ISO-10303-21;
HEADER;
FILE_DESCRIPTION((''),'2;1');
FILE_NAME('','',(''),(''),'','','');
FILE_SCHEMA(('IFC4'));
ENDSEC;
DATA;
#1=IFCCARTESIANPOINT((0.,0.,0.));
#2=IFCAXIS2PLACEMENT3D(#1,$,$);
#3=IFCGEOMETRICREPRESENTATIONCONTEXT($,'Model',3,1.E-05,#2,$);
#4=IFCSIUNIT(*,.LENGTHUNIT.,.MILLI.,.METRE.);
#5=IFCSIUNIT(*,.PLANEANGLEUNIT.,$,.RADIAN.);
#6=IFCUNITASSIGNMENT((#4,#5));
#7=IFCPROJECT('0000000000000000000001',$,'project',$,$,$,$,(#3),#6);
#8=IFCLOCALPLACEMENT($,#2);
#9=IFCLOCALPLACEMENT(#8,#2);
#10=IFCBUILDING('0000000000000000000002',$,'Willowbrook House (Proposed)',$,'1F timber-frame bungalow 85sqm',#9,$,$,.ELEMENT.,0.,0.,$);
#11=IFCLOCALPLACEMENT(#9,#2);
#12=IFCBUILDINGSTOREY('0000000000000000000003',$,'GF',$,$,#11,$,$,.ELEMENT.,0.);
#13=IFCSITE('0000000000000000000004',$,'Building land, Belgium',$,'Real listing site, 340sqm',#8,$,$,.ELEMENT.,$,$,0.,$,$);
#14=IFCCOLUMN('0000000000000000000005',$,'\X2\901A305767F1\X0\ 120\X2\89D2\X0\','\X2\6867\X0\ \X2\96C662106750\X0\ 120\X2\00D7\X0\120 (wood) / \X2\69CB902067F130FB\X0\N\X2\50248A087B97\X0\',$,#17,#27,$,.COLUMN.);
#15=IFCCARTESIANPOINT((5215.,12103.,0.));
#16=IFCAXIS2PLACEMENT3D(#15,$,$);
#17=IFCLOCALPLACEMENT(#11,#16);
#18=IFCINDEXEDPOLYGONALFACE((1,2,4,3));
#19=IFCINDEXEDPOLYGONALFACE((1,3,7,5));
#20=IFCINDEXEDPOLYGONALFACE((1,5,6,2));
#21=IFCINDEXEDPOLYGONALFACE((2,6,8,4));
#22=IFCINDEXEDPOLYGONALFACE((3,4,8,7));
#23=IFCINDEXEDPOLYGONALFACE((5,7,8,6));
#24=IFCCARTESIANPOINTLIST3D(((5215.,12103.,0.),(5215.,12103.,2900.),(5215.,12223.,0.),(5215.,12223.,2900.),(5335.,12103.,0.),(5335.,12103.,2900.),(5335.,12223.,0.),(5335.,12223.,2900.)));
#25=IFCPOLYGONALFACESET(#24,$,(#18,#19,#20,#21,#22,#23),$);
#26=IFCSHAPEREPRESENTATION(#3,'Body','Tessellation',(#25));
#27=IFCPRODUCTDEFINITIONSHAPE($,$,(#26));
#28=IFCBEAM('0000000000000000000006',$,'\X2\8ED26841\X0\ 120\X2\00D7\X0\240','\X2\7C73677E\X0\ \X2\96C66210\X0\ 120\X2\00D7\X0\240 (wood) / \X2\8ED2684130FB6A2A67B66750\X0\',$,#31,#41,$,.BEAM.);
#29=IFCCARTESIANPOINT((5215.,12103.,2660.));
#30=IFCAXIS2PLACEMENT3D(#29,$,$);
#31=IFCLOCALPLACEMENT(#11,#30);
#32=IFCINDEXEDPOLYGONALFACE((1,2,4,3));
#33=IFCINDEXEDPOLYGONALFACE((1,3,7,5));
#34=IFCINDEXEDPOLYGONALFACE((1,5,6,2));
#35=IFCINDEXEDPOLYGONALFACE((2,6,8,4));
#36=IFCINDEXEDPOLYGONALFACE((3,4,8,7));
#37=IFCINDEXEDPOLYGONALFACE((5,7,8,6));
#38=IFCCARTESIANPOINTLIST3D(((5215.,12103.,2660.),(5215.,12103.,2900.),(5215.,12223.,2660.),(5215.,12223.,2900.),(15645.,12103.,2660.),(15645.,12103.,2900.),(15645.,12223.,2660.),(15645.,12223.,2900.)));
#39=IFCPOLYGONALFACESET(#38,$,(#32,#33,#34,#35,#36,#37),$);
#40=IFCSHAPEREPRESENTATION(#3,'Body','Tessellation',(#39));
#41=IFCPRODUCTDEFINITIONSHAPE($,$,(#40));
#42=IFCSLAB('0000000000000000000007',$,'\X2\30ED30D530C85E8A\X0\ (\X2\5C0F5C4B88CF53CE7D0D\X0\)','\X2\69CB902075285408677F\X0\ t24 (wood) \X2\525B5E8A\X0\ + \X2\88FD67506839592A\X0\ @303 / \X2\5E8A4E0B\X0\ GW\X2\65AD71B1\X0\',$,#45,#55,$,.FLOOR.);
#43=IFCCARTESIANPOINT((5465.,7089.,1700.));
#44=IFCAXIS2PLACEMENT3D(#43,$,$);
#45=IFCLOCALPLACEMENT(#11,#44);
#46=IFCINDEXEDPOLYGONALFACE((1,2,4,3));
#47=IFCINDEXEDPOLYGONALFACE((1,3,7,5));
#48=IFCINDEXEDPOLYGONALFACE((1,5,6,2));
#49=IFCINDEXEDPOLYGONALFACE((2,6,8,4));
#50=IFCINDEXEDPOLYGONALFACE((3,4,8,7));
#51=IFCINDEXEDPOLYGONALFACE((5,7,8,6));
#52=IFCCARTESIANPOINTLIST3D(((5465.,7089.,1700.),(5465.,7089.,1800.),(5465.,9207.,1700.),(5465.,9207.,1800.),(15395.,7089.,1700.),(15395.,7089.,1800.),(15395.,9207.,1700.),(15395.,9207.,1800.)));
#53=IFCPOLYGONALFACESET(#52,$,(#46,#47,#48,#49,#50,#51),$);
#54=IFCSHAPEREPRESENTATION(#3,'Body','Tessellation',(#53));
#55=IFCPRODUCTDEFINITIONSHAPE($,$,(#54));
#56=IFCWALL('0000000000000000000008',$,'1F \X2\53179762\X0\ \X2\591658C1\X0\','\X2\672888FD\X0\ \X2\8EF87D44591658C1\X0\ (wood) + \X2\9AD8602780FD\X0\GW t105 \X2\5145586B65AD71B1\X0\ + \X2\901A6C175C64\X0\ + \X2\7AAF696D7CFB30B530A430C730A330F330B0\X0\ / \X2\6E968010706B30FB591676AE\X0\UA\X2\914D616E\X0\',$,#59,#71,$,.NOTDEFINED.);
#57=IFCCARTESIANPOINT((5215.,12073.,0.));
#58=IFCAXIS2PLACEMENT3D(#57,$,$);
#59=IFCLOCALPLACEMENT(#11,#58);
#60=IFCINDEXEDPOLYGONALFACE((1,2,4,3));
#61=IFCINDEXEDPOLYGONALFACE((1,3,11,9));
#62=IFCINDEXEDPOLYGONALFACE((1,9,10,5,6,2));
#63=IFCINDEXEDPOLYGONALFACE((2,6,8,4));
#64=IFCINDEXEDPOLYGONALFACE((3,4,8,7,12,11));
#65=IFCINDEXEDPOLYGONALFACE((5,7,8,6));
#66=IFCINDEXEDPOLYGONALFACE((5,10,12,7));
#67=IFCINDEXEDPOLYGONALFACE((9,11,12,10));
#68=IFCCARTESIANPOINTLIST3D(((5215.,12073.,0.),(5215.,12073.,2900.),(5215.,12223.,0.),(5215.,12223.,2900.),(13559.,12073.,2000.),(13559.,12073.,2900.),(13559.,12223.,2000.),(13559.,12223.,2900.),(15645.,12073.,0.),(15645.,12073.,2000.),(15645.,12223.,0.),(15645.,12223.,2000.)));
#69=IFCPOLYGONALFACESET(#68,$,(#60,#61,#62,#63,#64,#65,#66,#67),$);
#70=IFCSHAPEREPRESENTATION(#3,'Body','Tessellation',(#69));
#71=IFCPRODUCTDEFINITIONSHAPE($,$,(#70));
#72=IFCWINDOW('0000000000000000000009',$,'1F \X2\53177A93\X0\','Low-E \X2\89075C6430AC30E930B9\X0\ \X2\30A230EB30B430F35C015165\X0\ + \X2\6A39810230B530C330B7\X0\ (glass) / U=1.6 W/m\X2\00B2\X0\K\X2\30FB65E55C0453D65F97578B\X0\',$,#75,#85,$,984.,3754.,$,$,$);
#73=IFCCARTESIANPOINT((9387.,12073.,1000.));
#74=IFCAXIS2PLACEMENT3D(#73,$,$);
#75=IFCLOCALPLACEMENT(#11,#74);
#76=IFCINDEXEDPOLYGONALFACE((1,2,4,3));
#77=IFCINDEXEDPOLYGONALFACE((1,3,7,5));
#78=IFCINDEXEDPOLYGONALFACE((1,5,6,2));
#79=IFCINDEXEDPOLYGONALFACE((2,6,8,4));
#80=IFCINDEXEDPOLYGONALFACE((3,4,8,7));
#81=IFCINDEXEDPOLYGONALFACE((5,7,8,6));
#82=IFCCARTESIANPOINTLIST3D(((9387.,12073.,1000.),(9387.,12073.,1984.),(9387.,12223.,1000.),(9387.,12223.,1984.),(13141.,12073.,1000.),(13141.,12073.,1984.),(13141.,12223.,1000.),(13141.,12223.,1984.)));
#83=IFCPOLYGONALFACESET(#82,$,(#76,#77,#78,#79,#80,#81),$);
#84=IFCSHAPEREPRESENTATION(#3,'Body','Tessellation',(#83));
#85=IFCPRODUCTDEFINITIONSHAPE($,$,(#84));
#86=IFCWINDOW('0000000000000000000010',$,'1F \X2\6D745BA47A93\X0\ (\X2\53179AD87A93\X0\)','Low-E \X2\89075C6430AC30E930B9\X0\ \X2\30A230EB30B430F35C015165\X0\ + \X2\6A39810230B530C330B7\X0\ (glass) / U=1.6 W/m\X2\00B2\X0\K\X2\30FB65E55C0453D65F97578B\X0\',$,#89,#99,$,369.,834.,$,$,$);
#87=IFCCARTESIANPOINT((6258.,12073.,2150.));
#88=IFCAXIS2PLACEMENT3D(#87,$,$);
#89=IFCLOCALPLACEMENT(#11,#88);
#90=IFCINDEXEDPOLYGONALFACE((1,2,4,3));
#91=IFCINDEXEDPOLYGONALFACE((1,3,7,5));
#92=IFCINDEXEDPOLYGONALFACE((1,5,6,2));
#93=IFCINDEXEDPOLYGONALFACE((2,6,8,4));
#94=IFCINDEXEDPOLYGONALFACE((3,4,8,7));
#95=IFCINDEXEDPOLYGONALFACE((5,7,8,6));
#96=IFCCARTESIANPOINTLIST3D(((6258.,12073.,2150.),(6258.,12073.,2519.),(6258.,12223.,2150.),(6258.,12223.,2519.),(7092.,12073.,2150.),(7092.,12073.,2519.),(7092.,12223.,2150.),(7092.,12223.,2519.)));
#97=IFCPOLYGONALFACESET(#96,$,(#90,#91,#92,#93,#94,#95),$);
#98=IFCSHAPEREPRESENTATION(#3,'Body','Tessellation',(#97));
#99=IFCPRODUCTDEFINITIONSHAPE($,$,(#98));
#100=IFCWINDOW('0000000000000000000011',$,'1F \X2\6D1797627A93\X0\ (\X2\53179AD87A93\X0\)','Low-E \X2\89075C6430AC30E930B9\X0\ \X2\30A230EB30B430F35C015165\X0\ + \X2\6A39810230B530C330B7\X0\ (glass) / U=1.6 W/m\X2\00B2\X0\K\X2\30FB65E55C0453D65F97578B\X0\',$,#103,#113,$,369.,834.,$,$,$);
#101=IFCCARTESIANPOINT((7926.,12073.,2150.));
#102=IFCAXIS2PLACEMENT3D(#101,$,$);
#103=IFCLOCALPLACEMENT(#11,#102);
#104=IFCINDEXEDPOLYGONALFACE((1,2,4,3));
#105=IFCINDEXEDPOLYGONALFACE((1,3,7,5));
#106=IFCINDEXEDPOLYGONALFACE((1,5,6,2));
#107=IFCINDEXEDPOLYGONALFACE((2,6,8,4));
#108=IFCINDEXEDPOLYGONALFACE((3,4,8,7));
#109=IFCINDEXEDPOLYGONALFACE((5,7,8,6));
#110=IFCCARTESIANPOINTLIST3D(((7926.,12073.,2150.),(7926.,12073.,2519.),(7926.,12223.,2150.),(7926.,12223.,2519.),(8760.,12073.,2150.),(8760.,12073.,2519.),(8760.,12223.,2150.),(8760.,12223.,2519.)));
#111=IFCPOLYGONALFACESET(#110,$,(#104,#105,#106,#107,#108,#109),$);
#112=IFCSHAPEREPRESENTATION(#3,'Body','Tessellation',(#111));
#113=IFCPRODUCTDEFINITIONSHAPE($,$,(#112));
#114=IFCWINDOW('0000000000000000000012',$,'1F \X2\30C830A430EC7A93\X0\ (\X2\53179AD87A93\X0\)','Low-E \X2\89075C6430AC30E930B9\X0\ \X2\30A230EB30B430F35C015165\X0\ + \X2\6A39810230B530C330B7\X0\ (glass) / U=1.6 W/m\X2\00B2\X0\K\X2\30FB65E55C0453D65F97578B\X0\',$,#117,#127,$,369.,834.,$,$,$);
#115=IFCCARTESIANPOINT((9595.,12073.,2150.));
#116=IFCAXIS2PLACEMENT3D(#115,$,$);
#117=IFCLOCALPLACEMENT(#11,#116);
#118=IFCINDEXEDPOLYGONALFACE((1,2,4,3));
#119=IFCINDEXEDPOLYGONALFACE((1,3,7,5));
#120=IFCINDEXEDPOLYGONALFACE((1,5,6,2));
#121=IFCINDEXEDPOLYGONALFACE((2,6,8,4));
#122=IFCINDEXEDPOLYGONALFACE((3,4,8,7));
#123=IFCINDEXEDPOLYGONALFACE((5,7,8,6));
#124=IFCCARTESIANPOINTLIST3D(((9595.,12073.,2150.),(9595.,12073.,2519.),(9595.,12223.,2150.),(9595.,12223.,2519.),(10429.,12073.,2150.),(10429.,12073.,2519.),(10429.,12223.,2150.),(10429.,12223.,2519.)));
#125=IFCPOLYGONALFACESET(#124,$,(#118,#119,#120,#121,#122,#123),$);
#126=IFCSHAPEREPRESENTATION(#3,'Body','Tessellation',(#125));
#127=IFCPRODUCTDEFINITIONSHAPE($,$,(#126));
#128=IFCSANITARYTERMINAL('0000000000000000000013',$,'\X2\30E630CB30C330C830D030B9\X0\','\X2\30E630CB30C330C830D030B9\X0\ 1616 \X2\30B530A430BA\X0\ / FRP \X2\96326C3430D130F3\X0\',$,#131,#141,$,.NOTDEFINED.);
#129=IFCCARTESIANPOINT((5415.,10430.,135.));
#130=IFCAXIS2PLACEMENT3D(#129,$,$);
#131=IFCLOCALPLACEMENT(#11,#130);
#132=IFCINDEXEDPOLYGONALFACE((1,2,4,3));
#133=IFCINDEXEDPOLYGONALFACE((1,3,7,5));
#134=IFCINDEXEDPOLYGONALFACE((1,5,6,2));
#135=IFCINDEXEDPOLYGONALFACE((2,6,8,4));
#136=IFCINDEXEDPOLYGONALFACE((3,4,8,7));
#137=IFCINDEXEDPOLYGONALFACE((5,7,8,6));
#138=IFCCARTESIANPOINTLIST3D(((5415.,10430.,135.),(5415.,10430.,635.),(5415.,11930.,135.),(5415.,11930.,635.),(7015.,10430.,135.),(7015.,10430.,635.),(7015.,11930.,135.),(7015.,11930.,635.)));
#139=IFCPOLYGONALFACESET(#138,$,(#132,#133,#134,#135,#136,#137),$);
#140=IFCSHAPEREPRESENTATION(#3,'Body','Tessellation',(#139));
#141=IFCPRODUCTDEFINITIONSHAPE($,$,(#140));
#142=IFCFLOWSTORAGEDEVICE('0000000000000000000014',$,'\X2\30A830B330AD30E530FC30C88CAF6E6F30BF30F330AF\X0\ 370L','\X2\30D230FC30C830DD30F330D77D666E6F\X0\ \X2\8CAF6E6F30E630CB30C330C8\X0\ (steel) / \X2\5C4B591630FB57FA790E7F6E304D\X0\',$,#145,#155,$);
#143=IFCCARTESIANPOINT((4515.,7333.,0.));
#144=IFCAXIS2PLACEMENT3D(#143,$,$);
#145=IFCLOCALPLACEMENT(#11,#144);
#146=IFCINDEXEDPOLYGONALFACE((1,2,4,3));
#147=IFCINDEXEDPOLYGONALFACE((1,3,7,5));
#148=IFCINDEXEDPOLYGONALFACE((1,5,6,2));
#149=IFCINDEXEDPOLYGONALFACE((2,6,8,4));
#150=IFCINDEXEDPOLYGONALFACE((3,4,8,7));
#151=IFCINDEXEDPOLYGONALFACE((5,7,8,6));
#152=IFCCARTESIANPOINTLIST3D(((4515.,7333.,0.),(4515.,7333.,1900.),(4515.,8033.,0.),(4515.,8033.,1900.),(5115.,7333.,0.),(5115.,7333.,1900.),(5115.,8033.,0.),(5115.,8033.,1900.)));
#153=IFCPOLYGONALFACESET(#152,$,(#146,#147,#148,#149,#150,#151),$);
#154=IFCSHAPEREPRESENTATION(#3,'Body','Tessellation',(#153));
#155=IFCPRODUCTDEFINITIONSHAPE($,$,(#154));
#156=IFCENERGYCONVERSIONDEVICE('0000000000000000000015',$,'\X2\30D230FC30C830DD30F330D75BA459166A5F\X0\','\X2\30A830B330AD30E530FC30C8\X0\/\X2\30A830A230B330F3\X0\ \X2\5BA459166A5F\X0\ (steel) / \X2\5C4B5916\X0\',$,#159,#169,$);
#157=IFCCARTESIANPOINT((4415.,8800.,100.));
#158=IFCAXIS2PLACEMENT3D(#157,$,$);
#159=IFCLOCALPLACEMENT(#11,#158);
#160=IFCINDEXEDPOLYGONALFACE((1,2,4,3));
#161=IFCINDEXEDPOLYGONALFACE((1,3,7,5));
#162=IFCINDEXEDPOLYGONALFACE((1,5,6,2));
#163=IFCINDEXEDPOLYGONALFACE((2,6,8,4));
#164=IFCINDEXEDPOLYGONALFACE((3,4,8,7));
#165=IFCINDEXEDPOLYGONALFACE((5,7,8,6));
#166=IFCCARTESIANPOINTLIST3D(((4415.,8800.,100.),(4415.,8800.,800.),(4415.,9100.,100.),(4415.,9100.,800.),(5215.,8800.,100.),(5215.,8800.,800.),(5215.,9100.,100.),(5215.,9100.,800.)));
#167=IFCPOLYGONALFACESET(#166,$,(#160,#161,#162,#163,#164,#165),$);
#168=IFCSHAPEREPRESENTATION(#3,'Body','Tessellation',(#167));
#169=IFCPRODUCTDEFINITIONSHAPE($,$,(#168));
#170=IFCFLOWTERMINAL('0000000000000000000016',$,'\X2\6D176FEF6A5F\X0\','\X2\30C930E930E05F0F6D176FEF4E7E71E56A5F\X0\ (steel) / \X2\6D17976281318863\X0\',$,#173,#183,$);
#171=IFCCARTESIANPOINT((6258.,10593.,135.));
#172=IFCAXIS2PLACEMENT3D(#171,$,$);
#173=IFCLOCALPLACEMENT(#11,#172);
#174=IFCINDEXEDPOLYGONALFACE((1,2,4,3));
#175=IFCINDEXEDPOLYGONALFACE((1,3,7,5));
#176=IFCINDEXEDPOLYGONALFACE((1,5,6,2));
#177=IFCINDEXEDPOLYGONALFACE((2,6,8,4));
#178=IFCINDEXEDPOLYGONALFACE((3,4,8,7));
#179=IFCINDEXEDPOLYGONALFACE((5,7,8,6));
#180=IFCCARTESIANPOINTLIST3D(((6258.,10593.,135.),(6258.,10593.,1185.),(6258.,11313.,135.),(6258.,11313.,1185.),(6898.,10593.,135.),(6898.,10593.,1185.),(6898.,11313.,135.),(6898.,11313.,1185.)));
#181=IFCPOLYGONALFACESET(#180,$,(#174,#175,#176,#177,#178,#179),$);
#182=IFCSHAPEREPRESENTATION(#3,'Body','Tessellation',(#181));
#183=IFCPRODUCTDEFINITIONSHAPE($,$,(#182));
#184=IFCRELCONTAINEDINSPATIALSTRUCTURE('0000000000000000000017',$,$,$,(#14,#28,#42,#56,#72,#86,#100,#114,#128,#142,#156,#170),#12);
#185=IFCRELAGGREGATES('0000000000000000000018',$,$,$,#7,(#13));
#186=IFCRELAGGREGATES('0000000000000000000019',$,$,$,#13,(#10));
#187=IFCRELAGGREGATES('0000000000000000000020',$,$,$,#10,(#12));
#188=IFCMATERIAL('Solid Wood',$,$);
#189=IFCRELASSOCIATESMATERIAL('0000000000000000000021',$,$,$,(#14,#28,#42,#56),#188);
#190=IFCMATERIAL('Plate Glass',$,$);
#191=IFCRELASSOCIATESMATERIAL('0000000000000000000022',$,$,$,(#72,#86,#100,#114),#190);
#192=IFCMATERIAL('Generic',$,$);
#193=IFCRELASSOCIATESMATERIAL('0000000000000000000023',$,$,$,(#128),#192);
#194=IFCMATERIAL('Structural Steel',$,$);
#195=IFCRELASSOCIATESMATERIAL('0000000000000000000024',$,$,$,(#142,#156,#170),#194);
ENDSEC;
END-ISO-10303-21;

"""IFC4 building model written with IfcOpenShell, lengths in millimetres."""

from ifc_helpers import new_model, si_unit, frame, frame_2d, origin, place, context, project, spatial, rectangle, extrude, material, element, fill, save


model = new_model("IFC4")

# Units and contexts
model_context = context("Model", 3, precision=1e-05, world=origin())
ifc_project = project(units=[si_unit("LENGTHUNIT", "METRE", prefix="MILLI"), si_unit("PLANEANGLEUNIT", "RADIAN")], contexts=[model_context])

# Site, building, storey
site_placement = place(None, origin())
site = spatial("IfcSite", under=ifc_project, at=site_placement, Name="Building land, Belgium", ObjectType="Real listing site, 340sqm", CompositionType="ELEMENT", RefElevation=0.0)
building_placement = place(site_placement, origin())
building = spatial("IfcBuilding", under=site, at=building_placement, Name="Willowbrook House (Proposed)", ObjectType="1F timber-frame bungalow 85sqm", CompositionType="ELEMENT", ElevationOfRefHeight=0.0, ElevationOfTerrain=0.0)
storey_placement = place(building_placement, origin())
storey = spatial("IfcBuildingStorey", under=building, at=storey_placement, Name="GF", CompositionType="ELEMENT", Elevation=0.0)

# Column
ifc_material_1 = material(Name="Solid Wood")
column_1_placement = place(storey_placement, frame((5215.0, 12103.0, 0.0)))
element("IfcColumn", 1, at=column_1_placement, inside=storey, material=ifc_material_1, Name="通し柱 120角", Description="桧 集成材 120×120 (wood) / 構造柱・N値計算", PredefinedType="COLUMN", context=model_context, shape_type="SweptSolid", body=[
    extrude(rectangle(XDim=120.0, YDim=120.0, at=frame_2d((60.0, 60.0))), frame((5215.0, 12103.0, 0.0)), (0.0, 0.0, 1.0), 2900.0),
])

# Beam
beam_1_placement = place(storey_placement, frame((5215.0, 12103.0, 2660.0)))
element("IfcBeam", 2, at=beam_1_placement, inside=storey, material=ifc_material_1, Name="軒桁 120×240", Description="米松 集成 120×240 (wood) / 軒桁・横架材", PredefinedType="BEAM", context=model_context, shape_type="SweptSolid", body=[
    extrude(rectangle(XDim=10430.0, YDim=120.0, at=frame_2d((5215.0, 60.0))), frame((5215.0, 12103.0, 2660.0)), (0.0, 0.0, 1.0), 240.0),
])

# Slab
slab_placement = place(storey_placement, frame((5465.0, 7089.0, 1700.0)))
element("IfcSlab", 3, at=slab_placement, inside=storey, material=ifc_material_1, Name="ロフト床 (小屋裏収納)", Description="構造用合板 t24 (wood) 剛床 + 製材根太 @303 / 床下 GW断熱", PredefinedType="FLOOR", context=model_context, shape_type="SweptSolid", body=[
    extrude(rectangle(XDim=9930.0, YDim=2118.0, at=frame_2d((4965.0, 1059.0))), frame((5465.0, 7089.0, 1700.0)), (0.0, 0.0, 1.0), 100.0),
])

# Wall, openings, windows
wall_1_placement = place(storey_placement, frame((5215.0, 12073.0, 0.0)))
wall_1 = element("IfcWall", 4, at=wall_1_placement, inside=storey, material=ifc_material_1, Name="1F 北面 外壁", Description="木製 軸組外壁 (wood) + 高性能GW t105 充填断熱 + 通気層 + 窯業系サイディング / 準耐火・外皮UA配慮", PredefinedType="NOTDEFINED", context=model_context, shape_type="SweptSolid", body=[
    extrude(rectangle(XDim=10430.0, YDim=150.0, at=frame_2d((5215.0, 75.0))), frame((5215.0, 12073.0, 0.0)), (0.0, 0.0, 1.0), 2900.0),
])
opening_1_placement = place(storey_placement, frame((9387.0, 12073.0, 1000.0)))
opening_1 = element("IfcOpeningElement", 5, at=opening_1_placement, cuts=wall_1, PredefinedType="NOTDEFINED", context=model_context, shape_type="SweptSolid", body=[
    extrude(rectangle(XDim=3754.0, YDim=150.0, at=frame_2d((1877.0, 75.0))), frame((9387.0, 12073.0, 1000.0)), (0.0, 0.0, 1.0), 984.0),
])
opening_2_placement = place(storey_placement, frame((6258.0, 12073.0, 2150.0)))
opening_2 = element("IfcOpeningElement", 6, at=opening_2_placement, cuts=wall_1, PredefinedType="NOTDEFINED", context=model_context, shape_type="SweptSolid", body=[
    extrude(rectangle(XDim=834.0, YDim=150.0, at=frame_2d((417.0, 75.0))), frame((6258.0, 12073.0, 2150.0)), (0.0, 0.0, 1.0), 369.0),
])
opening_3_placement = place(storey_placement, frame((7926.0, 12073.0, 2150.0)))
opening_3 = element("IfcOpeningElement", 7, at=opening_3_placement, cuts=wall_1, PredefinedType="NOTDEFINED", context=model_context, shape_type="SweptSolid", body=[
    extrude(rectangle(XDim=834.0, YDim=150.0, at=frame_2d((417.0, 75.0))), frame((7926.0, 12073.0, 2150.0)), (0.0, 0.0, 1.0), 369.0),
])
opening_4_placement = place(storey_placement, frame((9595.0, 12073.0, 2150.0)))
opening_4 = element("IfcOpeningElement", 8, at=opening_4_placement, cuts=wall_1, PredefinedType="NOTDEFINED", context=model_context, shape_type="SweptSolid", body=[
    extrude(rectangle(XDim=834.0, YDim=150.0, at=frame_2d((417.0, 75.0))), frame((9595.0, 12073.0, 2150.0)), (0.0, 0.0, 1.0), 369.0),
])
ifc_material_2 = material(Name="Plate Glass")
window_1_placement = place(storey_placement, frame((9387.0, 12073.0, 1000.0)))
window_1 = element("IfcWindow", 9, at=window_1_placement, inside=storey, material=ifc_material_2, Name="1F 北窓", Description="Low-E 複層ガラス アルゴン封入 + 樹脂サッシ (glass) / U=1.6 W/m²K・日射取得型", OverallHeight=984.0, OverallWidth=3754.0, context=model_context, shape_type="SweptSolid", body=[
    extrude(rectangle(XDim=3754.0, YDim=150.0, at=frame_2d((1877.0, 75.0))), frame((9387.0, 12073.0, 1000.0)), (0.0, 0.0, 1.0), 984.0),
])
fill(opening_1, window_1)
window_2_placement = place(storey_placement, frame((6258.0, 12073.0, 2150.0)))
window_2 = element("IfcWindow", 10, at=window_2_placement, inside=storey, material=ifc_material_2, Name="1F 浴室窓 (北高窓)", Description="Low-E 複層ガラス アルゴン封入 + 樹脂サッシ (glass) / U=1.6 W/m²K・日射取得型", OverallHeight=369.0, OverallWidth=834.0, context=model_context, shape_type="SweptSolid", body=[
    extrude(rectangle(XDim=834.0, YDim=150.0, at=frame_2d((417.0, 75.0))), frame((6258.0, 12073.0, 2150.0)), (0.0, 0.0, 1.0), 369.0),
])
fill(opening_2, window_2)
window_3_placement = place(storey_placement, frame((7926.0, 12073.0, 2150.0)))
window_3 = element("IfcWindow", 11, at=window_3_placement, inside=storey, material=ifc_material_2, Name="1F 洗面窓 (北高窓)", Description="Low-E 複層ガラス アルゴン封入 + 樹脂サッシ (glass) / U=1.6 W/m²K・日射取得型", OverallHeight=369.0, OverallWidth=834.0, context=model_context, shape_type="SweptSolid", body=[
    extrude(rectangle(XDim=834.0, YDim=150.0, at=frame_2d((417.0, 75.0))), frame((7926.0, 12073.0, 2150.0)), (0.0, 0.0, 1.0), 369.0),
])
fill(opening_3, window_3)
window_4_placement = place(storey_placement, frame((9595.0, 12073.0, 2150.0)))
window_4 = element("IfcWindow", 12, at=window_4_placement, inside=storey, material=ifc_material_2, Name="1F トイレ窓 (北高窓)", Description="Low-E 複層ガラス アルゴン封入 + 樹脂サッシ (glass) / U=1.6 W/m²K・日射取得型", OverallHeight=369.0, OverallWidth=834.0, context=model_context, shape_type="SweptSolid", body=[
    extrude(rectangle(XDim=834.0, YDim=150.0, at=frame_2d((417.0, 75.0))), frame((9595.0, 12073.0, 2150.0)), (0.0, 0.0, 1.0), 369.0),
])
fill(opening_4, window_4)

# Sanitary terminal
ifc_material_3 = material(Name="Generic")
sanitary_terminal_placement = place(storey_placement, frame((5415.0, 10430.0, 135.0)))
element("IfcSanitaryTerminal", 13, at=sanitary_terminal_placement, inside=storey, material=ifc_material_3, Name="ユニットバス", Description="ユニットバス 1616 サイズ / FRP 防水パン", PredefinedType="NOTDEFINED", context=model_context, shape_type="SweptSolid", body=[
    extrude(rectangle(XDim=1600.0, YDim=1500.0, at=frame_2d((800.0, 750.0))), frame((5415.0, 10430.0, 135.0)), (0.0, 0.0, 1.0), 500.0),
])

# Flow storage device
ifc_material_4 = material(Name="Structural Steel")
flow_storage_device_placement = place(storey_placement, frame((4515.0, 7333.0, 0.0)))
element("IfcFlowStorageDevice", 14, at=flow_storage_device_placement, inside=storey, material=ifc_material_4, Name="エコキュート貯湯タンク 370L", Description="ヒートポンプ給湯 貯湯ユニット (steel) / 屋外・基礎置き", context=model_context, shape_type="SweptSolid", body=[
    extrude(rectangle(XDim=600.0, YDim=700.0, at=frame_2d((300.0, 350.0))), frame((4515.0, 7333.0, 0.0)), (0.0, 0.0, 1.0), 1900.0),
])

# Energy conversion device
energy_conversion_device_placement = place(storey_placement, frame((4415.0, 8800.0, 100.0)))
element("IfcEnergyConversionDevice", 15, at=energy_conversion_device_placement, inside=storey, material=ifc_material_4, Name="ヒートポンプ室外機", Description="エコキュート/エアコン 室外機 (steel) / 屋外", context=model_context, shape_type="SweptSolid", body=[
    extrude(rectangle(XDim=800.0, YDim=300.0, at=frame_2d((400.0, 150.0))), frame((4415.0, 8800.0, 100.0)), (0.0, 0.0, 1.0), 700.0),
])

# Flow terminal
flow_terminal_placement = place(storey_placement, frame((6258.0, 10593.0, 135.0)))
element("IfcFlowTerminal", 16, at=flow_terminal_placement, inside=storey, material=ifc_material_4, Name="洗濯機", Description="ドラム式洗濯乾燥機 (steel) / 洗面脱衣", context=model_context, shape_type="SweptSolid", body=[
    extrude(rectangle(XDim=640.0, YDim=720.0, at=frame_2d((320.0, 360.0))), frame((6258.0, 10593.0, 135.0)), (0.0, 0.0, 1.0), 1050.0),
])

save(model, "model.ifc")
